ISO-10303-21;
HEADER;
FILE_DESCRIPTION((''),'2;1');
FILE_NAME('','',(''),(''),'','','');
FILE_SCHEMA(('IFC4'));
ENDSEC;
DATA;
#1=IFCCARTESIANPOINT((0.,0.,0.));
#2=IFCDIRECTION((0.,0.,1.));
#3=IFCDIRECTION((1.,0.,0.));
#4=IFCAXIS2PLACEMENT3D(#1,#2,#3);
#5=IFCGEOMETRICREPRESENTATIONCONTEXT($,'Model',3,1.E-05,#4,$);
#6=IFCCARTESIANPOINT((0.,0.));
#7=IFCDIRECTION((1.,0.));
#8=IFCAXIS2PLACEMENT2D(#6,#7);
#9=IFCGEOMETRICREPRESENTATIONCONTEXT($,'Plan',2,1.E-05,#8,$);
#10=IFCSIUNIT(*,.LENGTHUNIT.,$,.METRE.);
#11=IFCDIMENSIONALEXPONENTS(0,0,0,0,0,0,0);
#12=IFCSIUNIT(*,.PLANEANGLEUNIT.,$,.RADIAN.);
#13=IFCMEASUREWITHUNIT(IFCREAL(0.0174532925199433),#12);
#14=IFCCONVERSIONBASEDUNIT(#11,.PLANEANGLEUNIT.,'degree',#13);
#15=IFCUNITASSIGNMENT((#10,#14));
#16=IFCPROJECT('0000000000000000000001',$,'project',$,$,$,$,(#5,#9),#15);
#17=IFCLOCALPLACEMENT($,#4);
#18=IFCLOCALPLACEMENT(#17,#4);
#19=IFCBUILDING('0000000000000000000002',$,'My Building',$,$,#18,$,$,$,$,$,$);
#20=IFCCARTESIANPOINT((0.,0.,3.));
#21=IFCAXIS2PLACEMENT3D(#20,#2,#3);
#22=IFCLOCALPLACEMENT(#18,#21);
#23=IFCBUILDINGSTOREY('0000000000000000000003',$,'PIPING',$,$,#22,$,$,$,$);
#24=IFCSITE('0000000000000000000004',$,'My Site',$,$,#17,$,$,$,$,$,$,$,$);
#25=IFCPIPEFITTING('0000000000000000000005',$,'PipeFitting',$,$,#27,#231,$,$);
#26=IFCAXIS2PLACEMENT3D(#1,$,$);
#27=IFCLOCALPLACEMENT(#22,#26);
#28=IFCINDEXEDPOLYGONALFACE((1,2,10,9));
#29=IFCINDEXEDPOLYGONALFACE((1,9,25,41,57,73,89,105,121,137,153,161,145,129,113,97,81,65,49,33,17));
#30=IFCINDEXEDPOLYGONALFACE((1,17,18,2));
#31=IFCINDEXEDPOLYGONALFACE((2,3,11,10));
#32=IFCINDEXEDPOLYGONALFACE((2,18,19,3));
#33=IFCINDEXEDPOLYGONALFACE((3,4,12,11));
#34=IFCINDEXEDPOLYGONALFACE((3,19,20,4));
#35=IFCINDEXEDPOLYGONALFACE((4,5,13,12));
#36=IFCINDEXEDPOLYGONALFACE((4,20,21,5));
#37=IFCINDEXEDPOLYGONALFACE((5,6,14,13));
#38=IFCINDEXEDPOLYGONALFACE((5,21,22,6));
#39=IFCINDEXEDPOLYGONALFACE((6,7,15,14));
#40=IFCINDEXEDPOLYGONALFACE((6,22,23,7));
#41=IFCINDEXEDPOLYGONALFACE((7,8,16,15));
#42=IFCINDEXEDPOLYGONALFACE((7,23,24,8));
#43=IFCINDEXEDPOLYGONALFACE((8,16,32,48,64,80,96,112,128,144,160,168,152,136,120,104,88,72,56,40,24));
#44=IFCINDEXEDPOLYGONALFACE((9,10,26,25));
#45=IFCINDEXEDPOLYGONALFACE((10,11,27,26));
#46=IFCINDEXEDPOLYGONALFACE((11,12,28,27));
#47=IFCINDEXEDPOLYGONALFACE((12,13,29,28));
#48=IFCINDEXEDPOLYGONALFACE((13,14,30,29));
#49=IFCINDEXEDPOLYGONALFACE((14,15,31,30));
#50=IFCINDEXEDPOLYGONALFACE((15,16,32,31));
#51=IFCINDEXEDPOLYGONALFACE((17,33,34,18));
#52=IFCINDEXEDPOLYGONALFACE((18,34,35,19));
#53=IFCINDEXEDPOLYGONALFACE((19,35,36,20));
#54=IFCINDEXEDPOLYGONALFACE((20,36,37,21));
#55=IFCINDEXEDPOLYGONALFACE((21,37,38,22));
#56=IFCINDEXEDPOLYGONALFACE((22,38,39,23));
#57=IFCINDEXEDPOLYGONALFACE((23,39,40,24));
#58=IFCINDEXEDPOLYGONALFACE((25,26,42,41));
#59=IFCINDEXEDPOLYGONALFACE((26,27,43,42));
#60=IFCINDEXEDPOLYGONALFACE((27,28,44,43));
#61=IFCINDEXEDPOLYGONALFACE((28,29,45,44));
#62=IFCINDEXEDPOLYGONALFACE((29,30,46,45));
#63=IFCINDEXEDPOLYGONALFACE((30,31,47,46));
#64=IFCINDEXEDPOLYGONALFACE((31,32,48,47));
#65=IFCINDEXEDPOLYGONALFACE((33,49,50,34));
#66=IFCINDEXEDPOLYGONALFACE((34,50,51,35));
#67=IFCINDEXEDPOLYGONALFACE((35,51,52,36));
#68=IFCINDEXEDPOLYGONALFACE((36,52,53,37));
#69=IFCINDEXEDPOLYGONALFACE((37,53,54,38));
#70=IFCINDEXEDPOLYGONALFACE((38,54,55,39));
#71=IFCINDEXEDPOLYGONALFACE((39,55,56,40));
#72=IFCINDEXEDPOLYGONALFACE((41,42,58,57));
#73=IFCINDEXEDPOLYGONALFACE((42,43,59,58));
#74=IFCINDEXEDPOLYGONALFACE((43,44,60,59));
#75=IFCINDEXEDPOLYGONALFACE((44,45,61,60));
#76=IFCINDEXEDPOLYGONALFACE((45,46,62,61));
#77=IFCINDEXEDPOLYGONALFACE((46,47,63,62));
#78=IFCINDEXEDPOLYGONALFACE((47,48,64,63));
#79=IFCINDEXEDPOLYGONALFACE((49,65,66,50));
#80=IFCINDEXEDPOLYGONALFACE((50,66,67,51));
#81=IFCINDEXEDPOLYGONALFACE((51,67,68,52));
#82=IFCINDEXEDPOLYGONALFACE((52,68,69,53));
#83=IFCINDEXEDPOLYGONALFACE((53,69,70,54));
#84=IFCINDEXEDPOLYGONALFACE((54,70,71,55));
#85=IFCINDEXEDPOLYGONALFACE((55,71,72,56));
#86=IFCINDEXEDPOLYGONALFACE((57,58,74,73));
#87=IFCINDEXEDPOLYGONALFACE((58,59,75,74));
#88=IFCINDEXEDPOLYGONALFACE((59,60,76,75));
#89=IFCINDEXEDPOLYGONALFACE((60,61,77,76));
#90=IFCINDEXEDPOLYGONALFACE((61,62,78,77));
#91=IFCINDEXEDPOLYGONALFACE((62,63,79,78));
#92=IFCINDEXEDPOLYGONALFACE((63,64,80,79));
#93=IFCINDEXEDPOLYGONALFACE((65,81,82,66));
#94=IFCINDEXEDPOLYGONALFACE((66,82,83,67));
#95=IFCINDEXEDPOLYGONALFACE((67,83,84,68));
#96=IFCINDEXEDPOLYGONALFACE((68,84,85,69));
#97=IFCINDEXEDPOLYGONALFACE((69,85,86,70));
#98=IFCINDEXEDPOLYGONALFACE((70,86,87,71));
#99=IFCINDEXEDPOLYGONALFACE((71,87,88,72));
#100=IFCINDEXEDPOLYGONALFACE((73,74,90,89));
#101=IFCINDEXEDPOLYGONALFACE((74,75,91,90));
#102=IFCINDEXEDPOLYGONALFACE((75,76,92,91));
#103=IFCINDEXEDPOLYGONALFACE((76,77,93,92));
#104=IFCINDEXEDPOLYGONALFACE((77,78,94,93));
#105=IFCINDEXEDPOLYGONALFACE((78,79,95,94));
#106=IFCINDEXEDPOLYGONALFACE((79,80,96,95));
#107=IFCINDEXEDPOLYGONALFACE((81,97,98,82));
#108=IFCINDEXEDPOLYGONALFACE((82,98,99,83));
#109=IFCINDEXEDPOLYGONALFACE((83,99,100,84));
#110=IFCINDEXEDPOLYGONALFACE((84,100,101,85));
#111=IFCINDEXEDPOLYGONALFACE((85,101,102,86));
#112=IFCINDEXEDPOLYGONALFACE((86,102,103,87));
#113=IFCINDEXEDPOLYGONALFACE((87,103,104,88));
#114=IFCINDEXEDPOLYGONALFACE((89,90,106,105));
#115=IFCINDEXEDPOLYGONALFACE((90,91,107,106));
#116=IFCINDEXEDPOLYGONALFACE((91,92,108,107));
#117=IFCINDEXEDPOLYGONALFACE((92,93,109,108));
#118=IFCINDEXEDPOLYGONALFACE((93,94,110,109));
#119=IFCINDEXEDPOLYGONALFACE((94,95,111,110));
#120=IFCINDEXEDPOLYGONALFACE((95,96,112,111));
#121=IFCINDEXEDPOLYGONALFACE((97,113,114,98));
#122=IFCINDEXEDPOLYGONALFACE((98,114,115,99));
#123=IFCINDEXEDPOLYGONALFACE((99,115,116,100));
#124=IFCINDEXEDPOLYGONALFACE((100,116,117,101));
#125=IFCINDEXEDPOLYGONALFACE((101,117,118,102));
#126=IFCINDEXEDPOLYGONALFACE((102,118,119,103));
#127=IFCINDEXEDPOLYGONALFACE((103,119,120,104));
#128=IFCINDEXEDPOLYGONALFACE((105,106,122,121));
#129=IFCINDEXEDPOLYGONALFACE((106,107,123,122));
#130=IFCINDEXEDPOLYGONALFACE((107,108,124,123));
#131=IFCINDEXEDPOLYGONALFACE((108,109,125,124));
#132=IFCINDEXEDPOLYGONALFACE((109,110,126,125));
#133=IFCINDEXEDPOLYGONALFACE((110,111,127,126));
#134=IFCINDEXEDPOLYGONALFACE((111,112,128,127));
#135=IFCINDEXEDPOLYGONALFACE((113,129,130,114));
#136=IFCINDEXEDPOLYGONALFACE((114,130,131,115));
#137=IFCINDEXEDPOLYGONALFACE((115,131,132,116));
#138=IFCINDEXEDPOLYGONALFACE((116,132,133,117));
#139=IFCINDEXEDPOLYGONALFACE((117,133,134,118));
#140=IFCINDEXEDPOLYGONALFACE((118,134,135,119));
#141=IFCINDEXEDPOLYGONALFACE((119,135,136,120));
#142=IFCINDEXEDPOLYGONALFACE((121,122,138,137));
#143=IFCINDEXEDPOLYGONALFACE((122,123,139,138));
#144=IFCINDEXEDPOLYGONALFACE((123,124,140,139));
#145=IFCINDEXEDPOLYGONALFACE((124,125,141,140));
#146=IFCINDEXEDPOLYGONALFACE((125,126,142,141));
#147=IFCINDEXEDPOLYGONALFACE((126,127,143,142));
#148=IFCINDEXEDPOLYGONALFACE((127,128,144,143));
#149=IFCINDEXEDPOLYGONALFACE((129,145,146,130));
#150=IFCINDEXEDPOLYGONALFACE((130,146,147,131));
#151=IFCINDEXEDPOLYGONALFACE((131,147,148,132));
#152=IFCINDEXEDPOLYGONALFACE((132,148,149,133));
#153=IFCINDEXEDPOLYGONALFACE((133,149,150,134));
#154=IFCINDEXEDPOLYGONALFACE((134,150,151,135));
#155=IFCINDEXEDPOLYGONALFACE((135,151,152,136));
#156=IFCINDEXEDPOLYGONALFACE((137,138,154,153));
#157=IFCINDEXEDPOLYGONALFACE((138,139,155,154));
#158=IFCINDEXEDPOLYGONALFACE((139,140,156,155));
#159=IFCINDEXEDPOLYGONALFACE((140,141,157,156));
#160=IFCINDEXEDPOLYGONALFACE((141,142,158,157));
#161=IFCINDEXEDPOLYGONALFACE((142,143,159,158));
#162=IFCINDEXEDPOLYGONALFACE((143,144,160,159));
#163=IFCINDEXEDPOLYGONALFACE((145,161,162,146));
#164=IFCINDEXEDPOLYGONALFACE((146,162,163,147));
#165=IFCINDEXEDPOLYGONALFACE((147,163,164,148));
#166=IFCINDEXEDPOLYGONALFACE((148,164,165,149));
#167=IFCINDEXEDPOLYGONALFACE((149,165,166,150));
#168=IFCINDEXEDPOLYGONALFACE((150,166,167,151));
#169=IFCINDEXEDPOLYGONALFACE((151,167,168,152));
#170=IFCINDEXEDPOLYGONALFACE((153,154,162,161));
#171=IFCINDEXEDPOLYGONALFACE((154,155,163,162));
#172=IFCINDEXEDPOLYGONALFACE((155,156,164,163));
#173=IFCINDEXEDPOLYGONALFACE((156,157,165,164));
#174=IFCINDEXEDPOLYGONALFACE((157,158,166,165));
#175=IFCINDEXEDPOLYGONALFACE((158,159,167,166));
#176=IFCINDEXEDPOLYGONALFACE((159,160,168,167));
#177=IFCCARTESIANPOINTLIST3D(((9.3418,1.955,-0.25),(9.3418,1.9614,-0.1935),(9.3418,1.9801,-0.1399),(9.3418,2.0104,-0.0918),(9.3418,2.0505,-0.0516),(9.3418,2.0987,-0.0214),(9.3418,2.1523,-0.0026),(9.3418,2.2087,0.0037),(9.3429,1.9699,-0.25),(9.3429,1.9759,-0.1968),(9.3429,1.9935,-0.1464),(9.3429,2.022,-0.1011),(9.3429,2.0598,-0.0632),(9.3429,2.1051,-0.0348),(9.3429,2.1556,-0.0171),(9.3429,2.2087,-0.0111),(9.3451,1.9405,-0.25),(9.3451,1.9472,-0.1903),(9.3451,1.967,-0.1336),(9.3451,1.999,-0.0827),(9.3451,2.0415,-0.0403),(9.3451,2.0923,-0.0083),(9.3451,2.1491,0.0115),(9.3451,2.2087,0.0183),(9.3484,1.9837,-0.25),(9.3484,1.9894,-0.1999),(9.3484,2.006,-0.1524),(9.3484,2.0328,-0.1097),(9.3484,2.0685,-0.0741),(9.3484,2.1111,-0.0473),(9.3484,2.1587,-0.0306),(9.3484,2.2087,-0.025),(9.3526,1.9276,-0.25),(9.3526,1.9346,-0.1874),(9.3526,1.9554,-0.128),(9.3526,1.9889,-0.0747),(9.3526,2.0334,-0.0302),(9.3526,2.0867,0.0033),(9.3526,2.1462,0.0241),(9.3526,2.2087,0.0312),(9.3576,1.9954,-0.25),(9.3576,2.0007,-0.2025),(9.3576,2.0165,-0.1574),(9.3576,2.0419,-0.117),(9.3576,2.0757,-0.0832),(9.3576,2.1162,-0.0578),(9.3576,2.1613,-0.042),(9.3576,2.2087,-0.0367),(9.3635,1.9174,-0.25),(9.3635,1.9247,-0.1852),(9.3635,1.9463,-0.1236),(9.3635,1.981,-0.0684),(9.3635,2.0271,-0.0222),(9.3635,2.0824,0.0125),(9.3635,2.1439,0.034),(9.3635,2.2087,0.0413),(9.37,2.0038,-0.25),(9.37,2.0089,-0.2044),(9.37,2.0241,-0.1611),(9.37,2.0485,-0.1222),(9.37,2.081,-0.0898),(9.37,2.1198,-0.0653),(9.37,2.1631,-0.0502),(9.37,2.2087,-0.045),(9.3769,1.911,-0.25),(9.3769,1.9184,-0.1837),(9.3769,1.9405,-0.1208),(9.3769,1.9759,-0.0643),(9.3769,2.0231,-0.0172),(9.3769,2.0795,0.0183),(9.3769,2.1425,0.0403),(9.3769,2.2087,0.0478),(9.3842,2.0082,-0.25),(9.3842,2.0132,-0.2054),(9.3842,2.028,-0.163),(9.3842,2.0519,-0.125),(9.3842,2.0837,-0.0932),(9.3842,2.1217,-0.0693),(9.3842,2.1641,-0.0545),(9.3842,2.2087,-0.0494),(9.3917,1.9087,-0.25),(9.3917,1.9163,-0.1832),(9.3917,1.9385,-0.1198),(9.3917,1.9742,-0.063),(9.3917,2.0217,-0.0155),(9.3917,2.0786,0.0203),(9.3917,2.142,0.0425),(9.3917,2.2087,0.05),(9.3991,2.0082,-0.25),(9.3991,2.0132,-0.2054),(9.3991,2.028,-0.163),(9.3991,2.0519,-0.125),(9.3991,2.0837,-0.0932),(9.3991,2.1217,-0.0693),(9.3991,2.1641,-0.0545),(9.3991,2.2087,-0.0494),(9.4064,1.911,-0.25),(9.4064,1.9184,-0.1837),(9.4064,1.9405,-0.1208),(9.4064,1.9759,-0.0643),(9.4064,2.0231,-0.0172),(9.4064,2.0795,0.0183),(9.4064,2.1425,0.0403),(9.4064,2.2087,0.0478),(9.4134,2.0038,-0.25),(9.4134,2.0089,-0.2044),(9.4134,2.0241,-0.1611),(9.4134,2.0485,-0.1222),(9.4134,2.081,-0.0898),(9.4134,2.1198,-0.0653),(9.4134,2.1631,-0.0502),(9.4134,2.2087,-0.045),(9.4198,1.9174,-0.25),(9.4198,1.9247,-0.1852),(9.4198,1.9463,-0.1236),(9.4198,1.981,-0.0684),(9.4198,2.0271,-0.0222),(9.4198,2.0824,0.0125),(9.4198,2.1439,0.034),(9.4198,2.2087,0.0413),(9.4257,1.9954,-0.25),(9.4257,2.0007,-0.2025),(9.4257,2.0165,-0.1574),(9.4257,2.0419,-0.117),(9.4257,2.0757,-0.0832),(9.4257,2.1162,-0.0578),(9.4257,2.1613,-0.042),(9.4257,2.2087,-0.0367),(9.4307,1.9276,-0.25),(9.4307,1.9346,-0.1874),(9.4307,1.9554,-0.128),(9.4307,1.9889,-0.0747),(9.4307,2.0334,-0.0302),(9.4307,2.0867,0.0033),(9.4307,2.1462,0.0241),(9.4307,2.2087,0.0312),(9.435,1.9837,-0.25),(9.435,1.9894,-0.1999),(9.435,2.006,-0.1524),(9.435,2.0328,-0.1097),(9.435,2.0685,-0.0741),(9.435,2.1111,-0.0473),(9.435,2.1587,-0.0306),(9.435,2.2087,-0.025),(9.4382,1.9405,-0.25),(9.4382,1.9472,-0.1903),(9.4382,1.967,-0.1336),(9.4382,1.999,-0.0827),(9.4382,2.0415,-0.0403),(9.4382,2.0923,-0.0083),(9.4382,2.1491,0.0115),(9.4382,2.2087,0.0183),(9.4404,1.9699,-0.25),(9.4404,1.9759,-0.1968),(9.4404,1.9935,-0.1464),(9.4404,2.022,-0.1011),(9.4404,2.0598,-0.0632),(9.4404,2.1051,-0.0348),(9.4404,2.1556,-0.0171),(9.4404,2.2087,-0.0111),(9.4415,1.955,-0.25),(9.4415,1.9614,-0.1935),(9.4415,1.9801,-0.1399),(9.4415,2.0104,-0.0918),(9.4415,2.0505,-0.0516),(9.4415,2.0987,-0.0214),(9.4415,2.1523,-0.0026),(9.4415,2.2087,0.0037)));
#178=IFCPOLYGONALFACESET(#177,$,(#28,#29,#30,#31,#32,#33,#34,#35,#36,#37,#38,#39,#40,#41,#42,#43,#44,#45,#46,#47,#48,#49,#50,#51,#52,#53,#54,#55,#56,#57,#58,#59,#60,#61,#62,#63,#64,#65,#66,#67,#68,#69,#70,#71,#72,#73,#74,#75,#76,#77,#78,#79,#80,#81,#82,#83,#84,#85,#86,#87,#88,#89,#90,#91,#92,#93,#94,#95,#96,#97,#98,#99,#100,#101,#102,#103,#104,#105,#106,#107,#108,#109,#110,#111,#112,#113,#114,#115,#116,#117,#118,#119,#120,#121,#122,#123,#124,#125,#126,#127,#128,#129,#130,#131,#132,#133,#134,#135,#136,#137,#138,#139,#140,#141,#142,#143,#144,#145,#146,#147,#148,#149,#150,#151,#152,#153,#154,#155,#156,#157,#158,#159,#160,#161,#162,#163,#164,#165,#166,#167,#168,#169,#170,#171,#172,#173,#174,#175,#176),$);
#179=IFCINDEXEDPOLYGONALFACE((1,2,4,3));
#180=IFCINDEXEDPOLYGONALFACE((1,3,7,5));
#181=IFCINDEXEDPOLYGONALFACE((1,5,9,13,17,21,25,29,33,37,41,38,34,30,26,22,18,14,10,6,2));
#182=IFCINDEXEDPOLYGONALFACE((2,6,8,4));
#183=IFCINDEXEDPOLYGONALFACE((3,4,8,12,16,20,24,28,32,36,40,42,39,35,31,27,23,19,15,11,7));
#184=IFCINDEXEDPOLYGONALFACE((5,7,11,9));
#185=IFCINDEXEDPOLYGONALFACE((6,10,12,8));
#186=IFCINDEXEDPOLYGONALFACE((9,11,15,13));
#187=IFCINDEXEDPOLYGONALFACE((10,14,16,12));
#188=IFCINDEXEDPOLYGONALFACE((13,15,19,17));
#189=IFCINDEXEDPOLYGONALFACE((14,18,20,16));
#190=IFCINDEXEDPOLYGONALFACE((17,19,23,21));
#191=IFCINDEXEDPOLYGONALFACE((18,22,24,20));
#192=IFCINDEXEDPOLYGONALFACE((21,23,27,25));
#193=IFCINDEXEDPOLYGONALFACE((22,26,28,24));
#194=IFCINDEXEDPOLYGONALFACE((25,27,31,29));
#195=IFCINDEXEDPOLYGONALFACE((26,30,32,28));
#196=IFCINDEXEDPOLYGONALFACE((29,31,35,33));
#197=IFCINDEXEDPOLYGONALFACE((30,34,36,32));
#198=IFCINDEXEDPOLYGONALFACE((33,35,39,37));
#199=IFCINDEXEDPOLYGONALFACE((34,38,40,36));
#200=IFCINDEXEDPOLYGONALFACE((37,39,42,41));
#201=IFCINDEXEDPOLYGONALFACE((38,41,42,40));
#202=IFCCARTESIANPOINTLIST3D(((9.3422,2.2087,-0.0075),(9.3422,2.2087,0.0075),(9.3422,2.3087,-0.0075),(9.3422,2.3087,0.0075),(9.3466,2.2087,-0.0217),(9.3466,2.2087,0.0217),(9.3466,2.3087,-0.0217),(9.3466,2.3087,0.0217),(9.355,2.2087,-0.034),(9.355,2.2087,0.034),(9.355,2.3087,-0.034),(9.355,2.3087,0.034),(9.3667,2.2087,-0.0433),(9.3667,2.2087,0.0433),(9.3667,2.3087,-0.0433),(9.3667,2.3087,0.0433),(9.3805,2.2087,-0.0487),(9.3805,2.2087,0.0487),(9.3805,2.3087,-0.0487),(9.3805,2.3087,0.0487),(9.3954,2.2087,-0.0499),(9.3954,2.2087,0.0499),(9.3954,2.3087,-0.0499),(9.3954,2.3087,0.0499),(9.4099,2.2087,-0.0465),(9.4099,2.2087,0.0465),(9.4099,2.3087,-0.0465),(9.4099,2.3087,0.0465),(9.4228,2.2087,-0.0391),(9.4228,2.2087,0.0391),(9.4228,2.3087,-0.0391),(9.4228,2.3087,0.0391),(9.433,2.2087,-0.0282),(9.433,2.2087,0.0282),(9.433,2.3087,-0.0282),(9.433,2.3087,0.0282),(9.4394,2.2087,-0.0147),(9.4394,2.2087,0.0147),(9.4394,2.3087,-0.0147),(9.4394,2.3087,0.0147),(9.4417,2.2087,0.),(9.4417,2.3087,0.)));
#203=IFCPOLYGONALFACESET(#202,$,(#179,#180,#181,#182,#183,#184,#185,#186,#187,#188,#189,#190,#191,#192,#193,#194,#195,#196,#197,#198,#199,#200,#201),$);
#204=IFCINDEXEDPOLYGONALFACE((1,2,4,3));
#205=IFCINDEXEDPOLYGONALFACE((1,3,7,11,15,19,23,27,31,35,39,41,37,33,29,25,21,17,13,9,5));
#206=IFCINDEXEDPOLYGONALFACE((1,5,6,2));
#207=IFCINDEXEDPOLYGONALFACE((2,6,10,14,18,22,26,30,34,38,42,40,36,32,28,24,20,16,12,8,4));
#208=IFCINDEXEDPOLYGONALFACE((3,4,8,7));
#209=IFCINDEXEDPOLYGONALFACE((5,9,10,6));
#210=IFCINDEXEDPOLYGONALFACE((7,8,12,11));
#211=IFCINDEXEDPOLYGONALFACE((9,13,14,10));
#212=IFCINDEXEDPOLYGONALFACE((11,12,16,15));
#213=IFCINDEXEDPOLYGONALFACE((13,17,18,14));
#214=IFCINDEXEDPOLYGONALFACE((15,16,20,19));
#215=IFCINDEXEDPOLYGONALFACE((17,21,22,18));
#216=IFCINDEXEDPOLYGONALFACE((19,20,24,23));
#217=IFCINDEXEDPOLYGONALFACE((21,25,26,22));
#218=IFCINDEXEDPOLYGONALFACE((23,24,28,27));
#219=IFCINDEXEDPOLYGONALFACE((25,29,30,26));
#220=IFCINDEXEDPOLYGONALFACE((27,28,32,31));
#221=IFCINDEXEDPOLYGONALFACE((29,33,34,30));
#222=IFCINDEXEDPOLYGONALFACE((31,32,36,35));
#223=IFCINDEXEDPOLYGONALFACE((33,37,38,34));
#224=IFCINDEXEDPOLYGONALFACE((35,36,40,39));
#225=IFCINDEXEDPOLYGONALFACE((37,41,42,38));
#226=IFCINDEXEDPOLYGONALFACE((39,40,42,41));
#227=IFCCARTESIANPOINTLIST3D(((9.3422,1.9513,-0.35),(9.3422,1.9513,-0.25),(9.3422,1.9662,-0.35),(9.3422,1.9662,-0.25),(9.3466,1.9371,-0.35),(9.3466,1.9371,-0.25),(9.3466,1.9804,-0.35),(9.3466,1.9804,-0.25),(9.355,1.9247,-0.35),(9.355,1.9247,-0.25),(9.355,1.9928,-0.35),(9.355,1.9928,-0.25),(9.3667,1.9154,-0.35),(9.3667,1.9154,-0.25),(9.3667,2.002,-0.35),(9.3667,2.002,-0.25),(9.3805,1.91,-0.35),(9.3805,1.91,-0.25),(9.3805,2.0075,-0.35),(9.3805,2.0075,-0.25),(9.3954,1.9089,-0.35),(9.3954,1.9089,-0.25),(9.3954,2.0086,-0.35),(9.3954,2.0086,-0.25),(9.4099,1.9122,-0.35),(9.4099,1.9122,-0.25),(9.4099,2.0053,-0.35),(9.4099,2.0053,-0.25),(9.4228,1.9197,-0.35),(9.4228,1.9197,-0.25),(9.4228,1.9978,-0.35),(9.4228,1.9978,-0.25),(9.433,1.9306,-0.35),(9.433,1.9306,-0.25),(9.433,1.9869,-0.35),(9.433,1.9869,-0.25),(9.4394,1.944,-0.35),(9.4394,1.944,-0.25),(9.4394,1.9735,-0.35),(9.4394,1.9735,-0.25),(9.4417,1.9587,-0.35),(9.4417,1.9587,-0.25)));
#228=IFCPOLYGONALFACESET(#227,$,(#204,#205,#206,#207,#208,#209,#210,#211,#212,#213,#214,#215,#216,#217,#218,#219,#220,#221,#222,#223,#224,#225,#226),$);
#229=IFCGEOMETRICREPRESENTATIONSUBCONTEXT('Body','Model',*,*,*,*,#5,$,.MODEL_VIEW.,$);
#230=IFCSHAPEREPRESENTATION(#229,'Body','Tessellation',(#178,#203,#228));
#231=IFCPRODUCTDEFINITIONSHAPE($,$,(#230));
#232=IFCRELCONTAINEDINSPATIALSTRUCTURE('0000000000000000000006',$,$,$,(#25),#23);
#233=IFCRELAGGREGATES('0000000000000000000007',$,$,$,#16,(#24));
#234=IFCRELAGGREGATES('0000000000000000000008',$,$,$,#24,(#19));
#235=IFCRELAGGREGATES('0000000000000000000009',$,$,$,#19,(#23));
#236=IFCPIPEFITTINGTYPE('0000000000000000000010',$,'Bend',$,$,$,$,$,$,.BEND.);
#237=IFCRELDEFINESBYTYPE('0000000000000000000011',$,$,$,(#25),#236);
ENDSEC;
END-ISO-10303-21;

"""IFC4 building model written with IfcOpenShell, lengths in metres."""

from ifc_helpers import new_model, entity, si_unit, converted_unit, frame, origin_with_axes, origin_2d_with_axis, place, context, subcontext, project, spatial, circle, extrude, source, transform, mapped, type_object, type_shapes, element, save


model = new_model("IFC4")

# Units and contexts
model_context = context("Model", 3, precision=1e-05, world=origin_with_axes())
plan_context = context("Plan", 2, precision=1e-05, world=origin_2d_with_axis())
body_context = subcontext(model_context, "Body", "Model", "MODEL_VIEW")
ifc_project = project(units=[si_unit("LENGTHUNIT", "METRE"), converted_unit("PLANEANGLEUNIT", "degree", entity("IfcReal", 0.0174532925199433), si_unit("PLANEANGLEUNIT", "RADIAN"), dimensions=[0, 0, 0, 0, 0, 0, 0])], contexts=[model_context, plan_context])

# Site, building, storey
site_placement = place(None, origin_with_axes())
site = spatial("IfcSite", under=ifc_project, at=site_placement, Name="My Site")
building_placement = place(site_placement, origin_with_axes())
building = spatial("IfcBuilding", under=site, at=building_placement, Name="My Building")
storey_placement = place(building_placement, frame((0.0, 0.0, 3.0), z_axis=(0.0, 0.0, 1.0), x_axis=(1.0, 0.0, 0.0)))
storey = spatial("IfcBuildingStorey", under=building, at=storey_placement, Name="PIPING")

# Pipe fitting
pipe_fitting_type = type_object("IfcPipeFittingType", Name="Bend", PredefinedType="BEND")
shared_shape = source(origin_with_axes(), body_context, "Body", "SolidModel", [
    entity("IfcSweptDiskSolid", entity("IfcIndexedPolyCurve", entity("IfcCartesianPointList3D", [[0.0, 0.0, 0.1], [0.0, -0.0732, 0.2768], [0.0, -0.25, 0.35]]), [entity("IfcArcIndex", [1, 2, 3])]), 0.05),
    extrude(circle(Radius=0.05), origin_with_axes(), (0.0, 0.0, 1.0), 0.1),
    extrude(circle(Radius=0.05), frame((0.0, -0.25, 0.35), z_axis=(0.0, -1.0, 0.0), x_axis=(1.0, 0.0, 0.0)), (0.0, 0.0, 1.0), 0.1),
])
type_shapes(pipe_fitting_type, [shared_shape])
for number, where, z_axis, x_axis, name in (
    (1, (9.3917, 2.3087, 0.0), (0.0, -1.0, 0.0), (1.0, 0.0, 0.0), "PipeFitting"),
):
    element("IfcPipeFitting", number, at=place(storey_placement, frame(where, z_axis=z_axis, x_axis=x_axis)), inside=storey, type_object=pipe_fitting_type, Name=name, context=body_context, shape_type="MappedRepresentation", body=[
        mapped(shared_shape, transform((0.0, 0.0, 0.0), x_axis=(1.0, 0.0, 0.0), y_axis=(0.0, 1.0, 0.0), z_axis=(0.0, 0.0, 1.0), scale=1.0)),
    ])

save(model, "model.ifc")
